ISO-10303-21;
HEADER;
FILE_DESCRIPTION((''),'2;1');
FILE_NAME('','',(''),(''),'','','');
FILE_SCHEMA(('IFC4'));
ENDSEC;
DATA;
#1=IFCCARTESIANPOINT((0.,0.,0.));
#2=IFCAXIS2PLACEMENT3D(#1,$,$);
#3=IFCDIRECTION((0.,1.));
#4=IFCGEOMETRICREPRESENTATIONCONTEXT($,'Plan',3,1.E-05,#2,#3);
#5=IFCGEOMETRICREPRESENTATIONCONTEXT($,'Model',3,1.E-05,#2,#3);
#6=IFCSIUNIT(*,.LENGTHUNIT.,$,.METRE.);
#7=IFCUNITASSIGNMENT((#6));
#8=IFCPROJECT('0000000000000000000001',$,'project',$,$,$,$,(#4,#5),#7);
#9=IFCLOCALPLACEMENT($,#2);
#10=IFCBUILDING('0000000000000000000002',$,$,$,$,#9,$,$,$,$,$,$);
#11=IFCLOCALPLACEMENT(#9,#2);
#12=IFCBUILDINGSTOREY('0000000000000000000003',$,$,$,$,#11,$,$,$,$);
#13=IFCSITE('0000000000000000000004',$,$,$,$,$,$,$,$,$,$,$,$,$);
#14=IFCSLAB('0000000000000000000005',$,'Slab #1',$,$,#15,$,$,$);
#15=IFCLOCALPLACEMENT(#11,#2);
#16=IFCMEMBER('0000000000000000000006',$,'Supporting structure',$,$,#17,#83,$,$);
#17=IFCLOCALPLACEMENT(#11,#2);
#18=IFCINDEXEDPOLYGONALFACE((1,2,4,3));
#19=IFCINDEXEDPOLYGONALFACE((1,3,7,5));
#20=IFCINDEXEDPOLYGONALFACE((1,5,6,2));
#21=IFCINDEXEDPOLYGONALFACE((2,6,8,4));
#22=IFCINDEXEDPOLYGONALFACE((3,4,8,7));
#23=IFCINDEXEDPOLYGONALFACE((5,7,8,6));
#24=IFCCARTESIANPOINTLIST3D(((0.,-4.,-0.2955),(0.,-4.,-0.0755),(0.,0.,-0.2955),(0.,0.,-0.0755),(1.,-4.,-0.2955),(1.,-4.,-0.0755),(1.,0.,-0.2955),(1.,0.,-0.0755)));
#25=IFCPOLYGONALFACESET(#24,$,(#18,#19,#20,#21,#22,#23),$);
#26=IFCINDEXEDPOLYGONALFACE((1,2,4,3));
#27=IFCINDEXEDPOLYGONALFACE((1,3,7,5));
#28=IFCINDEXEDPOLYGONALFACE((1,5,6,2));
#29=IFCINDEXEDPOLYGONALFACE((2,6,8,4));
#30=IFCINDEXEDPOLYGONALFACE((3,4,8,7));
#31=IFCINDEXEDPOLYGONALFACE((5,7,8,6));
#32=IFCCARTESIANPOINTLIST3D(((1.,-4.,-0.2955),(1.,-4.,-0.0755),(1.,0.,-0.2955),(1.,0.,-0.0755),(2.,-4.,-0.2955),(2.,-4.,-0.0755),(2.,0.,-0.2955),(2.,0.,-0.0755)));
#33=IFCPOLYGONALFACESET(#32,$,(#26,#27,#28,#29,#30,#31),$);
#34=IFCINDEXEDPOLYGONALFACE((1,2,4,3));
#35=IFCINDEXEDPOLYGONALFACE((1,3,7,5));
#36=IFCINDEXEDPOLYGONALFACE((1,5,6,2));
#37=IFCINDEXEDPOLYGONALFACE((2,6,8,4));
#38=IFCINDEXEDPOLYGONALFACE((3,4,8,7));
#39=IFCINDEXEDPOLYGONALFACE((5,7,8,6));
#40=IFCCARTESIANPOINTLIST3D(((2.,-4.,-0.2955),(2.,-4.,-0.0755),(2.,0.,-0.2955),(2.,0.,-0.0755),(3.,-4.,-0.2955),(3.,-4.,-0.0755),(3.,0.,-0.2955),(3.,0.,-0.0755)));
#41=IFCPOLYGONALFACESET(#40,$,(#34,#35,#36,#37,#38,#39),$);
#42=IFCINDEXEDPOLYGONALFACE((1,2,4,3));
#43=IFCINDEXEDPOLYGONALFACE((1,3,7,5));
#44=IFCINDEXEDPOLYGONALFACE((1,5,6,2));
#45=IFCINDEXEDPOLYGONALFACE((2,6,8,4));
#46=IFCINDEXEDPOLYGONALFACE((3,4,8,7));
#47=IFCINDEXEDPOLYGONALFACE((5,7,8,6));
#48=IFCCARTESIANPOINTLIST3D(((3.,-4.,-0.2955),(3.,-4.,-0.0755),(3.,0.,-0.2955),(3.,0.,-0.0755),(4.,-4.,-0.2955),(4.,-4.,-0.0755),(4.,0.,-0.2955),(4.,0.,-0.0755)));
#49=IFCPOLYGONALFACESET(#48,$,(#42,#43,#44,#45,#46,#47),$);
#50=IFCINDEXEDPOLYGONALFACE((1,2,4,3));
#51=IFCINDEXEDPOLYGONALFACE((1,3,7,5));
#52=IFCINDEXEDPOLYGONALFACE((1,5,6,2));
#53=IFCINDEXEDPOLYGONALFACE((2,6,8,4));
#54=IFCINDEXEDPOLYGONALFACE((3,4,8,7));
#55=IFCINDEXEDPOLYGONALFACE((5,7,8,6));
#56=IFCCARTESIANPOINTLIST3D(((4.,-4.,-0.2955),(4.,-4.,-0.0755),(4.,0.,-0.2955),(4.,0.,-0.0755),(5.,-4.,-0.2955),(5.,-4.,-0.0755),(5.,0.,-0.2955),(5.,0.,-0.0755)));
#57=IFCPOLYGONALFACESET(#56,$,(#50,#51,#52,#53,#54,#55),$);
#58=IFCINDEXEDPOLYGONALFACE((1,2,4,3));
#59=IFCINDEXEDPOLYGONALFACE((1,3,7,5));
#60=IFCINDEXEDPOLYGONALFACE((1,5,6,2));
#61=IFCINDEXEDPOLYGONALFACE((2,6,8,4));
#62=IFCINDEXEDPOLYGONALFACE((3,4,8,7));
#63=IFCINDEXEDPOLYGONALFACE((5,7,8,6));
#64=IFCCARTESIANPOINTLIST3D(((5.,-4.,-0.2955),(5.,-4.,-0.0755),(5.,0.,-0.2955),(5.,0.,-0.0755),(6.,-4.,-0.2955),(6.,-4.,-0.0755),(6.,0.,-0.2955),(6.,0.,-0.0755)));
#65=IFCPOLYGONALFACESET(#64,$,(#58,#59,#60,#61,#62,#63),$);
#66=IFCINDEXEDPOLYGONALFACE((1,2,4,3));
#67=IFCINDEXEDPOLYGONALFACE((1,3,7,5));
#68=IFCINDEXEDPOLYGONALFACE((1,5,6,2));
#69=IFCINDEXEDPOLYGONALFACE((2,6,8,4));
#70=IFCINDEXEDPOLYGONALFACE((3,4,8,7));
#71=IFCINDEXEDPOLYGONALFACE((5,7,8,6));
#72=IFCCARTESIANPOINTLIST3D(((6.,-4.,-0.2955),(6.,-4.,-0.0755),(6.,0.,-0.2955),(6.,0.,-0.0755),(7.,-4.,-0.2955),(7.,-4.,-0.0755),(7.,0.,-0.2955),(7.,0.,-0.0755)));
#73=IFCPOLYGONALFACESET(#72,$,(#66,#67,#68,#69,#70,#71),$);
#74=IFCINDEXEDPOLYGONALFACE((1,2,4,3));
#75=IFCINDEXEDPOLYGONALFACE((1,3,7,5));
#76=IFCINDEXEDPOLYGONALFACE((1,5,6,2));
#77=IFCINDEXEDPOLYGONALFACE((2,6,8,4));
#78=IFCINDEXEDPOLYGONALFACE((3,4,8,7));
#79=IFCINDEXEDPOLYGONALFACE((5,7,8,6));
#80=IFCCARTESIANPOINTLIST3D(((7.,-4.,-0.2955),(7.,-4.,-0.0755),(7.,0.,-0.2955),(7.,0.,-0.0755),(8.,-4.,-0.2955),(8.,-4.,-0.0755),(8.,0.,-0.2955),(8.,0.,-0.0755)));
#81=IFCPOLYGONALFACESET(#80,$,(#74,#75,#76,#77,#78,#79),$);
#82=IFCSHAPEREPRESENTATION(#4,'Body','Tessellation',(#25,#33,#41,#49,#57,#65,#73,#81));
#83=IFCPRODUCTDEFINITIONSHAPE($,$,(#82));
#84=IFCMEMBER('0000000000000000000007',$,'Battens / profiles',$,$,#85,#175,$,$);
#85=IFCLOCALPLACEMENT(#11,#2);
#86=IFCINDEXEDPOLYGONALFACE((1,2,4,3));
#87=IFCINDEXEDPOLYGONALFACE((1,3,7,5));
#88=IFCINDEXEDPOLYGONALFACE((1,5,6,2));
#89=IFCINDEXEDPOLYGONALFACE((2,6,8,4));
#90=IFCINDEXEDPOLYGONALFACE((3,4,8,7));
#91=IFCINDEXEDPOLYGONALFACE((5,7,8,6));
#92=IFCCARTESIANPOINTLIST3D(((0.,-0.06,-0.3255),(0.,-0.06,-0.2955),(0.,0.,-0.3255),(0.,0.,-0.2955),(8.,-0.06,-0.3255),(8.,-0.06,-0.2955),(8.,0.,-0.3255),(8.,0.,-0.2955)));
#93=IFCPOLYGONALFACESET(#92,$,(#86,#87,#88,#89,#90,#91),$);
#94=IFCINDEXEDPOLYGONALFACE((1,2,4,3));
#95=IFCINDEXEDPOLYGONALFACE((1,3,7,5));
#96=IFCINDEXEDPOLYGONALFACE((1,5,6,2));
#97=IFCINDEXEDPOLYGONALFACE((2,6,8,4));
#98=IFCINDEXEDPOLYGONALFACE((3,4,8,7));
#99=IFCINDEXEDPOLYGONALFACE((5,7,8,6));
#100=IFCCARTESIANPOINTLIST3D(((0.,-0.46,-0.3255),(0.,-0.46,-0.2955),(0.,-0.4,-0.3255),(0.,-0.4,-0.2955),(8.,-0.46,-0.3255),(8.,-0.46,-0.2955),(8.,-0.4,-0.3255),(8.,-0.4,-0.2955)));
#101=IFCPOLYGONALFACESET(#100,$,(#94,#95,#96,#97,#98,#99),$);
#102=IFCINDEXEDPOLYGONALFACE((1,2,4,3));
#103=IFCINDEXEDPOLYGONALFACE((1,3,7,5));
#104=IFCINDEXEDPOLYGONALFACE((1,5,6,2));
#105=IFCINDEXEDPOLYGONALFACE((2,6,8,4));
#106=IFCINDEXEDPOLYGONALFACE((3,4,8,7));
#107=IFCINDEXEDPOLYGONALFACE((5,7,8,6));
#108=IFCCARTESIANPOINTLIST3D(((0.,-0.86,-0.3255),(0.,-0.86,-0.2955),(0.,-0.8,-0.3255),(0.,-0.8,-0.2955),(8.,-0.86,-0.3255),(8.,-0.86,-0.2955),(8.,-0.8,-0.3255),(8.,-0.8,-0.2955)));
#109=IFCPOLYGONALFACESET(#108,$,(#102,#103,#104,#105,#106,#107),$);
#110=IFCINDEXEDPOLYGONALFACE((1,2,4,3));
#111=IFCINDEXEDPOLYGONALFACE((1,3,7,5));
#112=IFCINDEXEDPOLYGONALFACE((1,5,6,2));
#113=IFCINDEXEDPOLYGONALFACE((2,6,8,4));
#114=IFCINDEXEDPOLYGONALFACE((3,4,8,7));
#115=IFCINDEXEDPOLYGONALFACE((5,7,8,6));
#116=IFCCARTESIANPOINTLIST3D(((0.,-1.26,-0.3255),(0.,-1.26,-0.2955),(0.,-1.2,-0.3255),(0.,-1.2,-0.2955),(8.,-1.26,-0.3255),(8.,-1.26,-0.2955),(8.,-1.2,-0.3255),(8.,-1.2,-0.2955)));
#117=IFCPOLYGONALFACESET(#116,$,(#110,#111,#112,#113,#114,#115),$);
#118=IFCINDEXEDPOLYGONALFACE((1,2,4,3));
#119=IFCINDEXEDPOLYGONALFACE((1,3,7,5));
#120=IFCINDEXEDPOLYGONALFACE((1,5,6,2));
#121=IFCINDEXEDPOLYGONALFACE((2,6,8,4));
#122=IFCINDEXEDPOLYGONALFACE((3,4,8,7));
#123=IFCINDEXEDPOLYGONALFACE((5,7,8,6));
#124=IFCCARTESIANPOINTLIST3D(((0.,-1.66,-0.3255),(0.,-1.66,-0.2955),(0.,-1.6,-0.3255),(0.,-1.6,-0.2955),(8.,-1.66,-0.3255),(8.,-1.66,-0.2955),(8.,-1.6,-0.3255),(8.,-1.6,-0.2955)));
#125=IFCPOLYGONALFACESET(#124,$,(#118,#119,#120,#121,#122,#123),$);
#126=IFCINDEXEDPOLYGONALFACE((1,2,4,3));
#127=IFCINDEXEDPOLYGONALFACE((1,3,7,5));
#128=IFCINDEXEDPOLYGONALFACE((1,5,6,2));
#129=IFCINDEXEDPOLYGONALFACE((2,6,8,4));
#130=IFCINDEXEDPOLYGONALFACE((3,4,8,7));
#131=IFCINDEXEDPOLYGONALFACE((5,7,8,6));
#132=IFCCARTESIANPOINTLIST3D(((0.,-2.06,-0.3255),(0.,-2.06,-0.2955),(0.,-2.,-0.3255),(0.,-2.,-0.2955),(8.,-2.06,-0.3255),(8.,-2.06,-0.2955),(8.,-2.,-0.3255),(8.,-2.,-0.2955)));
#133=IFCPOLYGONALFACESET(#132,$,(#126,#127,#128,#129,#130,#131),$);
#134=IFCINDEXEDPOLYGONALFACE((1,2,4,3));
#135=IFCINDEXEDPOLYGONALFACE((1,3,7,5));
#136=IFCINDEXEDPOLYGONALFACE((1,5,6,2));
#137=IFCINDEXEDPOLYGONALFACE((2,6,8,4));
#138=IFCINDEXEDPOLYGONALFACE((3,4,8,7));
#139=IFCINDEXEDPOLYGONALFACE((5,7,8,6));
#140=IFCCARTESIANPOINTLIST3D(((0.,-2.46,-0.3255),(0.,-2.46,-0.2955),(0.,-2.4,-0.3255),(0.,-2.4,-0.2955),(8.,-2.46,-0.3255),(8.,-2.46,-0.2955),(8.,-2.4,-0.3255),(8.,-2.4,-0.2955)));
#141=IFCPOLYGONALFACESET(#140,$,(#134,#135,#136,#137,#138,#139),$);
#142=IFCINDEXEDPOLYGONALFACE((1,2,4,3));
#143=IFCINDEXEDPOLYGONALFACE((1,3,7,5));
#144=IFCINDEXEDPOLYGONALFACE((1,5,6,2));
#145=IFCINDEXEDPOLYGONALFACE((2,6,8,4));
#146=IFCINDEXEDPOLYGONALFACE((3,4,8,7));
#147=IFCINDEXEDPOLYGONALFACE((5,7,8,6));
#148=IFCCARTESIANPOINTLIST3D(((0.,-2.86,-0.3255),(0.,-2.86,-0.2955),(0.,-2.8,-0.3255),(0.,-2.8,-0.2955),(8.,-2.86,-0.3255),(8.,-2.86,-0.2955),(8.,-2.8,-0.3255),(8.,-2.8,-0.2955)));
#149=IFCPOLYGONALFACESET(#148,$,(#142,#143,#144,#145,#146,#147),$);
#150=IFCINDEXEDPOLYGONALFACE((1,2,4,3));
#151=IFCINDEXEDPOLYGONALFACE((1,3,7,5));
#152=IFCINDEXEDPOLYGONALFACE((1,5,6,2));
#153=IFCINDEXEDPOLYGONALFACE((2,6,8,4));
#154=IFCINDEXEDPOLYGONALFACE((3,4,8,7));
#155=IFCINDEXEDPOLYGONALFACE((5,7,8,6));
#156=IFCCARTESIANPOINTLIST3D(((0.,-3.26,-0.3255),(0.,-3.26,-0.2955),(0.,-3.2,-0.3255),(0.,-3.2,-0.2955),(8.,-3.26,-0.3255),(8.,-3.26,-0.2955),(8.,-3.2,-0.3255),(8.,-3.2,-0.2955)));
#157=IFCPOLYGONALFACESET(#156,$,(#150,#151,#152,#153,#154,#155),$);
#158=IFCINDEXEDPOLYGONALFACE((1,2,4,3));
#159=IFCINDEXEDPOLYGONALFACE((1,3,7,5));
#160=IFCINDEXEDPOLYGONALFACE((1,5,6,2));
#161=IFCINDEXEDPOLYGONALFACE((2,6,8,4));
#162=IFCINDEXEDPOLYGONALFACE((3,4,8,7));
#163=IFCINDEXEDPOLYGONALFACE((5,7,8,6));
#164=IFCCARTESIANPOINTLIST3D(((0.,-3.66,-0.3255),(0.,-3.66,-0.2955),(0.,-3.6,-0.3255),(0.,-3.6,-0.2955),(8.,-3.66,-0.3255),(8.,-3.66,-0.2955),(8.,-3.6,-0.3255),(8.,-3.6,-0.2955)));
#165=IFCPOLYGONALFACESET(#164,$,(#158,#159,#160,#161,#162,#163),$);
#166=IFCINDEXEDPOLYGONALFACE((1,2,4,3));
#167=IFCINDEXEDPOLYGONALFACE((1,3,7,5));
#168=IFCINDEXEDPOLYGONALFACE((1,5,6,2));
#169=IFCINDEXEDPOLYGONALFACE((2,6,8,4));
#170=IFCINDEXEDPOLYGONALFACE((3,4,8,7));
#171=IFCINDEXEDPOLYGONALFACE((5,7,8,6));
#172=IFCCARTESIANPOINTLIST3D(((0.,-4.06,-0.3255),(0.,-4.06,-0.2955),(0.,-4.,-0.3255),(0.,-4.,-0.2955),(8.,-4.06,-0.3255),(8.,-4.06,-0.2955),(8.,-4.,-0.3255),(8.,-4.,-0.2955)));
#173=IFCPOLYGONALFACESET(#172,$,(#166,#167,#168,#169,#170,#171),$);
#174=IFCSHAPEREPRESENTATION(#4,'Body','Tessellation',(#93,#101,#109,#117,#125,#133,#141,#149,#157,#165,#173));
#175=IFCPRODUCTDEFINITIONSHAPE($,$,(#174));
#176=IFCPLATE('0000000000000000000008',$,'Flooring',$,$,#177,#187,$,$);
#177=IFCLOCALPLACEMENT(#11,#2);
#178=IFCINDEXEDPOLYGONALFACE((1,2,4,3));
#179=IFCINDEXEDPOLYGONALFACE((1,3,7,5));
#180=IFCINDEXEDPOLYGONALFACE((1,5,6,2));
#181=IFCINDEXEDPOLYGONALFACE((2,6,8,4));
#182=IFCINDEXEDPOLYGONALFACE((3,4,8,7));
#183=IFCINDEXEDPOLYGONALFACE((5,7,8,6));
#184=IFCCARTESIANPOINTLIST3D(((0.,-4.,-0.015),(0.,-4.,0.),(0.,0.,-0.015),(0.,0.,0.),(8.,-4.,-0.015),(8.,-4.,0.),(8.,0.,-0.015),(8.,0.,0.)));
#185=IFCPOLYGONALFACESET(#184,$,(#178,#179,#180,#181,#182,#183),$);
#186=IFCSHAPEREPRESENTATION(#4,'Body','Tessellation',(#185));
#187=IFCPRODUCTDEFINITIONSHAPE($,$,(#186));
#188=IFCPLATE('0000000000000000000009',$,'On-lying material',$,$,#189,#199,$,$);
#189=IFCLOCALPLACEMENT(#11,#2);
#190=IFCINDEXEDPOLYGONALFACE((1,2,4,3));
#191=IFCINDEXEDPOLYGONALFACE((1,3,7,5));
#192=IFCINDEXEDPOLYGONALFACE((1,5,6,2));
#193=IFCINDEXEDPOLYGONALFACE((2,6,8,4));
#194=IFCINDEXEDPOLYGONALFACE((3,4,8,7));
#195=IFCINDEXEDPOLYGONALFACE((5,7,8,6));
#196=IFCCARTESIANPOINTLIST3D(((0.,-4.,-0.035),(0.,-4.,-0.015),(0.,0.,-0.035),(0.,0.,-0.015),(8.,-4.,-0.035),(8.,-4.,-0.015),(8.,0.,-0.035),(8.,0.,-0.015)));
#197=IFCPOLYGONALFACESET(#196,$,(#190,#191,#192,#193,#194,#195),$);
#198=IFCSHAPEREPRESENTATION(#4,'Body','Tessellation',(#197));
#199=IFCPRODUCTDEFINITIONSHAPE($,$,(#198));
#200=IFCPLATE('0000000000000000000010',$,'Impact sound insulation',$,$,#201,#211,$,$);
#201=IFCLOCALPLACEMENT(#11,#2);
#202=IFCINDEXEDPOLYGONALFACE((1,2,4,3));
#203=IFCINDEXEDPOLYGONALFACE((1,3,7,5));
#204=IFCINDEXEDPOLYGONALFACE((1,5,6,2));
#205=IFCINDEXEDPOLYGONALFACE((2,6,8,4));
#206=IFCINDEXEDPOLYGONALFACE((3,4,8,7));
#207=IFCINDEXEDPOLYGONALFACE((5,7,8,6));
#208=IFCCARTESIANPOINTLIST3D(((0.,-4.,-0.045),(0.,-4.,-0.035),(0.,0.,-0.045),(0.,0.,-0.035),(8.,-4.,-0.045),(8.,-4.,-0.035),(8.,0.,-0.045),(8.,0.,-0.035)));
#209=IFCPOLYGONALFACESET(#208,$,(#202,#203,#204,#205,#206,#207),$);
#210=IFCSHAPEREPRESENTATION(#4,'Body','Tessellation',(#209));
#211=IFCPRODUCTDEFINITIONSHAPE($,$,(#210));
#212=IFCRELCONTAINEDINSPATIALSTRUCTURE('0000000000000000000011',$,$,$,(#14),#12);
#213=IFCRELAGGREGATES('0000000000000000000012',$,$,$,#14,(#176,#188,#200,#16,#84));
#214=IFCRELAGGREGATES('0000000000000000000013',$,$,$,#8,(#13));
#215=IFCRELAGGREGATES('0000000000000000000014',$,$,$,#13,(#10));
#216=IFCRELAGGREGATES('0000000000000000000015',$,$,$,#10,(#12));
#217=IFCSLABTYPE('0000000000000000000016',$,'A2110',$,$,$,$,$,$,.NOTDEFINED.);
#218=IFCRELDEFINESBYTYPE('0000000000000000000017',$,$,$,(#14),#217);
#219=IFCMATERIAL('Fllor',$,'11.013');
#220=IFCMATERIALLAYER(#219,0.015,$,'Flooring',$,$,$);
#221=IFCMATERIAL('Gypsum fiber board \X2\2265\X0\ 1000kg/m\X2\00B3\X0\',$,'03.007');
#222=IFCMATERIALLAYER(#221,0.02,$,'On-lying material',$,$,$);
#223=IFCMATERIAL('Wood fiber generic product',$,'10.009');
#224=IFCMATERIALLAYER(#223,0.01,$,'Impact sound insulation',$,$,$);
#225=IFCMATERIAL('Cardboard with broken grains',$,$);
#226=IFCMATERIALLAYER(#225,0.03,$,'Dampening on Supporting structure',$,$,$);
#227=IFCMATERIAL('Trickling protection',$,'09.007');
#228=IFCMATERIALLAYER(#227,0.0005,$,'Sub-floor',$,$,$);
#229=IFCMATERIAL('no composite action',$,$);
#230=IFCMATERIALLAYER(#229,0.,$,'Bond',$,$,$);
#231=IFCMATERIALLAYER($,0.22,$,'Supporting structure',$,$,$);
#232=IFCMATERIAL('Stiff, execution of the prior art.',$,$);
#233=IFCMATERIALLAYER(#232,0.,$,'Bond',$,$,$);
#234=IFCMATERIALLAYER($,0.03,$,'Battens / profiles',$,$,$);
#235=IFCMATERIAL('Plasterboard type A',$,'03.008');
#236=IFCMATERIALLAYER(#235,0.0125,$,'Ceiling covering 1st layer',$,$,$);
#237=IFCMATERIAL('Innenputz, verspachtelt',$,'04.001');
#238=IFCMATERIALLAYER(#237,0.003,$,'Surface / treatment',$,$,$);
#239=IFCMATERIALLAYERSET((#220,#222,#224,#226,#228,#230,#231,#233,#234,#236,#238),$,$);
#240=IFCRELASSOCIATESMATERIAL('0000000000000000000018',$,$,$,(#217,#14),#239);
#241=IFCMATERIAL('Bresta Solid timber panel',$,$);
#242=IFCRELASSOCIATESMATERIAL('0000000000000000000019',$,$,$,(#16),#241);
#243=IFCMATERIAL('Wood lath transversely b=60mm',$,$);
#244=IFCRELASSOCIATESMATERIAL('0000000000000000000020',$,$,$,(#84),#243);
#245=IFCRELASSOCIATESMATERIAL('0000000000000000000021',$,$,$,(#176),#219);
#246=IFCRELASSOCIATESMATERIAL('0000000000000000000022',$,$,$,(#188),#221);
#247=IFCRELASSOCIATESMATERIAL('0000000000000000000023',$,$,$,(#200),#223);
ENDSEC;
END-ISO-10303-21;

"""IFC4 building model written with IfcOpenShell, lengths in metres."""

from ifc_helpers import new_model, si_unit, direction, frame, frame_2d, origin, origin_with_axes, place, context, project, spatial, rectangle, extrude, material, layer, layer_set, type_object, element, aggregate, save


model = new_model("IFC4")

# Units and contexts
plan_context = context("Plan", 3, precision=1e-05, world=origin(), true_north=direction((0.0, 1.0)))
model_context = context("Model", 3, precision=1e-05, world=origin(), true_north=direction((0.0, 1.0)))
ifc_project = project(units=[si_unit("LENGTHUNIT", "METRE")], contexts=[plan_context, model_context])

# Site, building, storey
site = spatial("IfcSite", under=ifc_project)
building_placement = place(None, origin())
building = spatial("IfcBuilding", under=site, at=building_placement)
storey_placement = place(building_placement, origin())
storey = spatial("IfcBuildingStorey", under=building, at=storey_placement)

# Slab, members, plates
ifc_material_1 = material(Name="Fllor", Category="11.013")
ifc_layer_1 = layer(ifc_material_1, 0.015, Name="Flooring")
ifc_material_2 = material(Name="Gypsum fiber board ≥ 1000kg/m³", Category="03.007")
ifc_layer_2 = layer(ifc_material_2, 0.02, Name="On-lying material")
ifc_material_3 = material(Name="Wood fiber generic product", Category="10.009")
ifc_layer_3 = layer(ifc_material_3, 0.01, Name="Impact sound insulation")
ifc_material_4 = material(Name="Cardboard with broken grains")
ifc_layer_4 = layer(ifc_material_4, 0.03, Name="Dampening on Supporting structure")
ifc_material_5 = material(Name="Trickling protection", Category="09.007")
ifc_layer_5 = layer(ifc_material_5, 0.0005, Name="Sub-floor")
ifc_material_6 = material(Name="no composite action")
ifc_layer_6 = layer(ifc_material_6, 0.0, Name="Bond")
ifc_layer_7 = layer(None, 0.22, Name="Supporting structure")
ifc_material_7 = material(Name="Stiff, execution of the prior art.")
ifc_layer_8 = layer(ifc_material_7, 0.0, Name="Bond")
ifc_layer_9 = layer(None, 0.03, Name="Battens / profiles")
ifc_material_8 = material(Name="Plasterboard type A", Category="03.008")
ifc_layer_10 = layer(ifc_material_8, 0.0125, Name="Ceiling covering 1st layer")
ifc_material_9 = material(Name="Innenputz, verspachtelt", Category="04.001")
ifc_layer_11 = layer(ifc_material_9, 0.003, Name="Surface / treatment")
ifc_layer_set = layer_set([ifc_layer_1, ifc_layer_2, ifc_layer_3, ifc_layer_4, ifc_layer_5, ifc_layer_6, ifc_layer_7, ifc_layer_8, ifc_layer_9, ifc_layer_10, ifc_layer_11])
slab_type = type_object("IfcSlabType", Name="A2110", PredefinedType="NOTDEFINED", material=ifc_layer_set)
slab_placement = place(None, frame((0.0, 0.0, 0.0), z_axis=(0.0, 0.0, -1.0), x_axis=(1.0, 0.0, 0.0)))
slab = element("IfcSlab", 1, at=slab_placement, inside=storey, type_object=slab_type, material=ifc_layer_set, Name="Slab #1")
ifc_material_10 = material(Name="Bresta Solid timber panel")
member_1_placement = place(slab_placement, origin())
member_1 = element("IfcMember", 2, at=member_1_placement, material=ifc_material_10, Name="Supporting structure", context=plan_context, shape_type="SweptSolid", body=[
    extrude(rectangle(XDim=1.0, YDim=0.22, at=frame_2d((0.5, 0.11), x_axis=(1.0, 0.0))), frame((0.0, 4.0, 0.0755), z_axis=(0.0, -1.0, 0.0), x_axis=(1.0, 0.0, 0.0)), (0.0, 0.0, 1.0), 4.0),
    extrude(rectangle(XDim=1.0, YDim=0.22, at=frame_2d((0.5, 0.11), x_axis=(1.0, 0.0))), frame((1.0, 4.0, 0.0755), z_axis=(0.0, -1.0, 0.0), x_axis=(1.0, 0.0, 0.0)), (0.0, 0.0, 1.0), 4.0),
    extrude(rectangle(XDim=1.0, YDim=0.22, at=frame_2d((0.5, 0.11), x_axis=(1.0, 0.0))), frame((2.0, 4.0, 0.0755), z_axis=(0.0, -1.0, 0.0), x_axis=(1.0, 0.0, 0.0)), (0.0, 0.0, 1.0), 4.0),
    extrude(rectangle(XDim=1.0, YDim=0.22, at=frame_2d((0.5, 0.11), x_axis=(1.0, 0.0))), frame((3.0, 4.0, 0.0755), z_axis=(0.0, -1.0, 0.0), x_axis=(1.0, 0.0, 0.0)), (0.0, 0.0, 1.0), 4.0),
    extrude(rectangle(XDim=1.0, YDim=0.22, at=frame_2d((0.5, 0.11), x_axis=(1.0, 0.0))), frame((4.0, 4.0, 0.0755), z_axis=(0.0, -1.0, 0.0), x_axis=(1.0, 0.0, 0.0)), (0.0, 0.0, 1.0), 4.0),
    extrude(rectangle(XDim=1.0, YDim=0.22, at=frame_2d((0.5, 0.11), x_axis=(1.0, 0.0))), frame((5.0, 4.0, 0.0755), z_axis=(0.0, -1.0, 0.0), x_axis=(1.0, 0.0, 0.0)), (0.0, 0.0, 1.0), 4.0),
    extrude(rectangle(XDim=1.0, YDim=0.22, at=frame_2d((0.5, 0.11), x_axis=(1.0, 0.0))), frame((6.0, 4.0, 0.0755), z_axis=(0.0, -1.0, 0.0), x_axis=(1.0, 0.0, 0.0)), (0.0, 0.0, 1.0), 4.0),
    extrude(rectangle(XDim=1.0, YDim=0.22, at=frame_2d((0.5, 0.11), x_axis=(1.0, 0.0))), frame((7.0, 4.0, 0.0755), z_axis=(0.0, -1.0, 0.0), x_axis=(1.0, 0.0, 0.0)), (0.0, 0.0, 1.0), 4.0),
])
ifc_material_11 = material(Name="Wood lath transversely b=60mm")
member_2_placement = place(slab_placement, origin())
member_2 = element("IfcMember", 3, at=member_2_placement, material=ifc_material_11, Name="Battens / profiles", context=plan_context, shape_type="SweptSolid", body=[
    extrude(rectangle(XDim=0.06, YDim=0.03, at=frame_2d((0.03, 0.015), x_axis=(1.0, 0.0))), frame((0.0, 0.0, 0.2955), z_axis=(1.0, 0.0, 0.0), x_axis=(0.0, 1.0, 0.0)), (0.0, 0.0, 1.0), 8.0),
    extrude(rectangle(XDim=0.06, YDim=0.03, at=frame_2d((0.03, 0.015), x_axis=(1.0, 0.0))), frame((0.0, 0.4, 0.2955), z_axis=(1.0, 0.0, 0.0), x_axis=(0.0, 1.0, 0.0)), (0.0, 0.0, 1.0), 8.0),
    extrude(rectangle(XDim=0.06, YDim=0.03, at=frame_2d((0.03, 0.015), x_axis=(1.0, 0.0))), frame((0.0, 0.8, 0.2955), z_axis=(1.0, 0.0, 0.0), x_axis=(0.0, 1.0, 0.0)), (0.0, 0.0, 1.0), 8.0),
    extrude(rectangle(XDim=0.06, YDim=0.03, at=frame_2d((0.03, 0.015), x_axis=(1.0, 0.0))), frame((0.0, 1.2, 0.2955), z_axis=(1.0, 0.0, 0.0), x_axis=(0.0, 1.0, 0.0)), (0.0, 0.0, 1.0), 8.0),
    extrude(rectangle(XDim=0.06, YDim=0.03, at=frame_2d((0.03, 0.015), x_axis=(1.0, 0.0))), frame((0.0, 1.6, 0.2955), z_axis=(1.0, 0.0, 0.0), x_axis=(0.0, 1.0, 0.0)), (0.0, 0.0, 1.0), 8.0),
    extrude(rectangle(XDim=0.06, YDim=0.03, at=frame_2d((0.03, 0.015), x_axis=(1.0, 0.0))), frame((0.0, 2.0, 0.2955), z_axis=(1.0, 0.0, 0.0), x_axis=(0.0, 1.0, 0.0)), (0.0, 0.0, 1.0), 8.0),
    extrude(rectangle(XDim=0.06, YDim=0.03, at=frame_2d((0.03, 0.015), x_axis=(1.0, 0.0))), frame((0.0, 2.4, 0.2955), z_axis=(1.0, 0.0, 0.0), x_axis=(0.0, 1.0, 0.0)), (0.0, 0.0, 1.0), 8.0),
    extrude(rectangle(XDim=0.06, YDim=0.03, at=frame_2d((0.03, 0.015), x_axis=(1.0, 0.0))), frame((0.0, 2.8, 0.2955), z_axis=(1.0, 0.0, 0.0), x_axis=(0.0, 1.0, 0.0)), (0.0, 0.0, 1.0), 8.0),
    extrude(rectangle(XDim=0.06, YDim=0.03, at=frame_2d((0.03, 0.015), x_axis=(1.0, 0.0))), frame((0.0, 3.2, 0.2955), z_axis=(1.0, 0.0, 0.0), x_axis=(0.0, 1.0, 0.0)), (0.0, 0.0, 1.0), 8.0),
    extrude(rectangle(XDim=0.06, YDim=0.03, at=frame_2d((0.03, 0.015), x_axis=(1.0, 0.0))), frame((0.0, 3.6, 0.2955), z_axis=(1.0, 0.0, 0.0), x_axis=(0.0, 1.0, 0.0)), (0.0, 0.0, 1.0), 8.0),
    extrude(rectangle(XDim=0.06, YDim=0.03, at=frame_2d((0.03, 0.015), x_axis=(1.0, 0.0))), frame((0.0, 4.0, 0.2955), z_axis=(1.0, 0.0, 0.0), x_axis=(0.0, 1.0, 0.0)), (0.0, 0.0, 1.0), 8.0),
])
plate_1_placement = place(slab_placement, origin())
plate_1 = element("IfcPlate", 4, at=plate_1_placement, material=ifc_material_1, Name="Flooring", context=plan_context, shape_type="SweptSolid", body=[
    extrude(rectangle(XDim=8.0, YDim=4.0, at=frame_2d((4.0, 2.0), x_axis=(1.0, 0.0))), origin_with_axes(), (0.0, 0.0, 1.0), 0.015),
])
plate_2_placement = place(slab_placement, origin())
plate_2 = element("IfcPlate", 5, at=plate_2_placement, material=ifc_material_2, Name="On-lying material", context=plan_context, shape_type="SweptSolid", body=[
    extrude(rectangle(XDim=8.0, YDim=4.0, at=frame_2d((4.0, 2.0), x_axis=(1.0, 0.0))), frame((0.0, 0.0, 0.015), z_axis=(0.0, 0.0, 1.0), x_axis=(1.0, 0.0, 0.0)), (0.0, 0.0, 1.0), 0.02),
])
plate_3_placement = place(slab_placement, origin())
plate_3 = element("IfcPlate", 6, at=plate_3_placement, material=ifc_material_3, Name="Impact sound insulation", context=plan_context, shape_type="SweptSolid", body=[
    extrude(rectangle(XDim=8.0, YDim=4.0, at=frame_2d((4.0, 2.0), x_axis=(1.0, 0.0))), frame((0.0, 0.0, 0.035), z_axis=(0.0, 0.0, 1.0), x_axis=(1.0, 0.0, 0.0)), (0.0, 0.0, 1.0), 0.01),
])
aggregate(slab, [plate_1, plate_2, plate_3, member_1, member_2])

save(model, "model.ifc")
